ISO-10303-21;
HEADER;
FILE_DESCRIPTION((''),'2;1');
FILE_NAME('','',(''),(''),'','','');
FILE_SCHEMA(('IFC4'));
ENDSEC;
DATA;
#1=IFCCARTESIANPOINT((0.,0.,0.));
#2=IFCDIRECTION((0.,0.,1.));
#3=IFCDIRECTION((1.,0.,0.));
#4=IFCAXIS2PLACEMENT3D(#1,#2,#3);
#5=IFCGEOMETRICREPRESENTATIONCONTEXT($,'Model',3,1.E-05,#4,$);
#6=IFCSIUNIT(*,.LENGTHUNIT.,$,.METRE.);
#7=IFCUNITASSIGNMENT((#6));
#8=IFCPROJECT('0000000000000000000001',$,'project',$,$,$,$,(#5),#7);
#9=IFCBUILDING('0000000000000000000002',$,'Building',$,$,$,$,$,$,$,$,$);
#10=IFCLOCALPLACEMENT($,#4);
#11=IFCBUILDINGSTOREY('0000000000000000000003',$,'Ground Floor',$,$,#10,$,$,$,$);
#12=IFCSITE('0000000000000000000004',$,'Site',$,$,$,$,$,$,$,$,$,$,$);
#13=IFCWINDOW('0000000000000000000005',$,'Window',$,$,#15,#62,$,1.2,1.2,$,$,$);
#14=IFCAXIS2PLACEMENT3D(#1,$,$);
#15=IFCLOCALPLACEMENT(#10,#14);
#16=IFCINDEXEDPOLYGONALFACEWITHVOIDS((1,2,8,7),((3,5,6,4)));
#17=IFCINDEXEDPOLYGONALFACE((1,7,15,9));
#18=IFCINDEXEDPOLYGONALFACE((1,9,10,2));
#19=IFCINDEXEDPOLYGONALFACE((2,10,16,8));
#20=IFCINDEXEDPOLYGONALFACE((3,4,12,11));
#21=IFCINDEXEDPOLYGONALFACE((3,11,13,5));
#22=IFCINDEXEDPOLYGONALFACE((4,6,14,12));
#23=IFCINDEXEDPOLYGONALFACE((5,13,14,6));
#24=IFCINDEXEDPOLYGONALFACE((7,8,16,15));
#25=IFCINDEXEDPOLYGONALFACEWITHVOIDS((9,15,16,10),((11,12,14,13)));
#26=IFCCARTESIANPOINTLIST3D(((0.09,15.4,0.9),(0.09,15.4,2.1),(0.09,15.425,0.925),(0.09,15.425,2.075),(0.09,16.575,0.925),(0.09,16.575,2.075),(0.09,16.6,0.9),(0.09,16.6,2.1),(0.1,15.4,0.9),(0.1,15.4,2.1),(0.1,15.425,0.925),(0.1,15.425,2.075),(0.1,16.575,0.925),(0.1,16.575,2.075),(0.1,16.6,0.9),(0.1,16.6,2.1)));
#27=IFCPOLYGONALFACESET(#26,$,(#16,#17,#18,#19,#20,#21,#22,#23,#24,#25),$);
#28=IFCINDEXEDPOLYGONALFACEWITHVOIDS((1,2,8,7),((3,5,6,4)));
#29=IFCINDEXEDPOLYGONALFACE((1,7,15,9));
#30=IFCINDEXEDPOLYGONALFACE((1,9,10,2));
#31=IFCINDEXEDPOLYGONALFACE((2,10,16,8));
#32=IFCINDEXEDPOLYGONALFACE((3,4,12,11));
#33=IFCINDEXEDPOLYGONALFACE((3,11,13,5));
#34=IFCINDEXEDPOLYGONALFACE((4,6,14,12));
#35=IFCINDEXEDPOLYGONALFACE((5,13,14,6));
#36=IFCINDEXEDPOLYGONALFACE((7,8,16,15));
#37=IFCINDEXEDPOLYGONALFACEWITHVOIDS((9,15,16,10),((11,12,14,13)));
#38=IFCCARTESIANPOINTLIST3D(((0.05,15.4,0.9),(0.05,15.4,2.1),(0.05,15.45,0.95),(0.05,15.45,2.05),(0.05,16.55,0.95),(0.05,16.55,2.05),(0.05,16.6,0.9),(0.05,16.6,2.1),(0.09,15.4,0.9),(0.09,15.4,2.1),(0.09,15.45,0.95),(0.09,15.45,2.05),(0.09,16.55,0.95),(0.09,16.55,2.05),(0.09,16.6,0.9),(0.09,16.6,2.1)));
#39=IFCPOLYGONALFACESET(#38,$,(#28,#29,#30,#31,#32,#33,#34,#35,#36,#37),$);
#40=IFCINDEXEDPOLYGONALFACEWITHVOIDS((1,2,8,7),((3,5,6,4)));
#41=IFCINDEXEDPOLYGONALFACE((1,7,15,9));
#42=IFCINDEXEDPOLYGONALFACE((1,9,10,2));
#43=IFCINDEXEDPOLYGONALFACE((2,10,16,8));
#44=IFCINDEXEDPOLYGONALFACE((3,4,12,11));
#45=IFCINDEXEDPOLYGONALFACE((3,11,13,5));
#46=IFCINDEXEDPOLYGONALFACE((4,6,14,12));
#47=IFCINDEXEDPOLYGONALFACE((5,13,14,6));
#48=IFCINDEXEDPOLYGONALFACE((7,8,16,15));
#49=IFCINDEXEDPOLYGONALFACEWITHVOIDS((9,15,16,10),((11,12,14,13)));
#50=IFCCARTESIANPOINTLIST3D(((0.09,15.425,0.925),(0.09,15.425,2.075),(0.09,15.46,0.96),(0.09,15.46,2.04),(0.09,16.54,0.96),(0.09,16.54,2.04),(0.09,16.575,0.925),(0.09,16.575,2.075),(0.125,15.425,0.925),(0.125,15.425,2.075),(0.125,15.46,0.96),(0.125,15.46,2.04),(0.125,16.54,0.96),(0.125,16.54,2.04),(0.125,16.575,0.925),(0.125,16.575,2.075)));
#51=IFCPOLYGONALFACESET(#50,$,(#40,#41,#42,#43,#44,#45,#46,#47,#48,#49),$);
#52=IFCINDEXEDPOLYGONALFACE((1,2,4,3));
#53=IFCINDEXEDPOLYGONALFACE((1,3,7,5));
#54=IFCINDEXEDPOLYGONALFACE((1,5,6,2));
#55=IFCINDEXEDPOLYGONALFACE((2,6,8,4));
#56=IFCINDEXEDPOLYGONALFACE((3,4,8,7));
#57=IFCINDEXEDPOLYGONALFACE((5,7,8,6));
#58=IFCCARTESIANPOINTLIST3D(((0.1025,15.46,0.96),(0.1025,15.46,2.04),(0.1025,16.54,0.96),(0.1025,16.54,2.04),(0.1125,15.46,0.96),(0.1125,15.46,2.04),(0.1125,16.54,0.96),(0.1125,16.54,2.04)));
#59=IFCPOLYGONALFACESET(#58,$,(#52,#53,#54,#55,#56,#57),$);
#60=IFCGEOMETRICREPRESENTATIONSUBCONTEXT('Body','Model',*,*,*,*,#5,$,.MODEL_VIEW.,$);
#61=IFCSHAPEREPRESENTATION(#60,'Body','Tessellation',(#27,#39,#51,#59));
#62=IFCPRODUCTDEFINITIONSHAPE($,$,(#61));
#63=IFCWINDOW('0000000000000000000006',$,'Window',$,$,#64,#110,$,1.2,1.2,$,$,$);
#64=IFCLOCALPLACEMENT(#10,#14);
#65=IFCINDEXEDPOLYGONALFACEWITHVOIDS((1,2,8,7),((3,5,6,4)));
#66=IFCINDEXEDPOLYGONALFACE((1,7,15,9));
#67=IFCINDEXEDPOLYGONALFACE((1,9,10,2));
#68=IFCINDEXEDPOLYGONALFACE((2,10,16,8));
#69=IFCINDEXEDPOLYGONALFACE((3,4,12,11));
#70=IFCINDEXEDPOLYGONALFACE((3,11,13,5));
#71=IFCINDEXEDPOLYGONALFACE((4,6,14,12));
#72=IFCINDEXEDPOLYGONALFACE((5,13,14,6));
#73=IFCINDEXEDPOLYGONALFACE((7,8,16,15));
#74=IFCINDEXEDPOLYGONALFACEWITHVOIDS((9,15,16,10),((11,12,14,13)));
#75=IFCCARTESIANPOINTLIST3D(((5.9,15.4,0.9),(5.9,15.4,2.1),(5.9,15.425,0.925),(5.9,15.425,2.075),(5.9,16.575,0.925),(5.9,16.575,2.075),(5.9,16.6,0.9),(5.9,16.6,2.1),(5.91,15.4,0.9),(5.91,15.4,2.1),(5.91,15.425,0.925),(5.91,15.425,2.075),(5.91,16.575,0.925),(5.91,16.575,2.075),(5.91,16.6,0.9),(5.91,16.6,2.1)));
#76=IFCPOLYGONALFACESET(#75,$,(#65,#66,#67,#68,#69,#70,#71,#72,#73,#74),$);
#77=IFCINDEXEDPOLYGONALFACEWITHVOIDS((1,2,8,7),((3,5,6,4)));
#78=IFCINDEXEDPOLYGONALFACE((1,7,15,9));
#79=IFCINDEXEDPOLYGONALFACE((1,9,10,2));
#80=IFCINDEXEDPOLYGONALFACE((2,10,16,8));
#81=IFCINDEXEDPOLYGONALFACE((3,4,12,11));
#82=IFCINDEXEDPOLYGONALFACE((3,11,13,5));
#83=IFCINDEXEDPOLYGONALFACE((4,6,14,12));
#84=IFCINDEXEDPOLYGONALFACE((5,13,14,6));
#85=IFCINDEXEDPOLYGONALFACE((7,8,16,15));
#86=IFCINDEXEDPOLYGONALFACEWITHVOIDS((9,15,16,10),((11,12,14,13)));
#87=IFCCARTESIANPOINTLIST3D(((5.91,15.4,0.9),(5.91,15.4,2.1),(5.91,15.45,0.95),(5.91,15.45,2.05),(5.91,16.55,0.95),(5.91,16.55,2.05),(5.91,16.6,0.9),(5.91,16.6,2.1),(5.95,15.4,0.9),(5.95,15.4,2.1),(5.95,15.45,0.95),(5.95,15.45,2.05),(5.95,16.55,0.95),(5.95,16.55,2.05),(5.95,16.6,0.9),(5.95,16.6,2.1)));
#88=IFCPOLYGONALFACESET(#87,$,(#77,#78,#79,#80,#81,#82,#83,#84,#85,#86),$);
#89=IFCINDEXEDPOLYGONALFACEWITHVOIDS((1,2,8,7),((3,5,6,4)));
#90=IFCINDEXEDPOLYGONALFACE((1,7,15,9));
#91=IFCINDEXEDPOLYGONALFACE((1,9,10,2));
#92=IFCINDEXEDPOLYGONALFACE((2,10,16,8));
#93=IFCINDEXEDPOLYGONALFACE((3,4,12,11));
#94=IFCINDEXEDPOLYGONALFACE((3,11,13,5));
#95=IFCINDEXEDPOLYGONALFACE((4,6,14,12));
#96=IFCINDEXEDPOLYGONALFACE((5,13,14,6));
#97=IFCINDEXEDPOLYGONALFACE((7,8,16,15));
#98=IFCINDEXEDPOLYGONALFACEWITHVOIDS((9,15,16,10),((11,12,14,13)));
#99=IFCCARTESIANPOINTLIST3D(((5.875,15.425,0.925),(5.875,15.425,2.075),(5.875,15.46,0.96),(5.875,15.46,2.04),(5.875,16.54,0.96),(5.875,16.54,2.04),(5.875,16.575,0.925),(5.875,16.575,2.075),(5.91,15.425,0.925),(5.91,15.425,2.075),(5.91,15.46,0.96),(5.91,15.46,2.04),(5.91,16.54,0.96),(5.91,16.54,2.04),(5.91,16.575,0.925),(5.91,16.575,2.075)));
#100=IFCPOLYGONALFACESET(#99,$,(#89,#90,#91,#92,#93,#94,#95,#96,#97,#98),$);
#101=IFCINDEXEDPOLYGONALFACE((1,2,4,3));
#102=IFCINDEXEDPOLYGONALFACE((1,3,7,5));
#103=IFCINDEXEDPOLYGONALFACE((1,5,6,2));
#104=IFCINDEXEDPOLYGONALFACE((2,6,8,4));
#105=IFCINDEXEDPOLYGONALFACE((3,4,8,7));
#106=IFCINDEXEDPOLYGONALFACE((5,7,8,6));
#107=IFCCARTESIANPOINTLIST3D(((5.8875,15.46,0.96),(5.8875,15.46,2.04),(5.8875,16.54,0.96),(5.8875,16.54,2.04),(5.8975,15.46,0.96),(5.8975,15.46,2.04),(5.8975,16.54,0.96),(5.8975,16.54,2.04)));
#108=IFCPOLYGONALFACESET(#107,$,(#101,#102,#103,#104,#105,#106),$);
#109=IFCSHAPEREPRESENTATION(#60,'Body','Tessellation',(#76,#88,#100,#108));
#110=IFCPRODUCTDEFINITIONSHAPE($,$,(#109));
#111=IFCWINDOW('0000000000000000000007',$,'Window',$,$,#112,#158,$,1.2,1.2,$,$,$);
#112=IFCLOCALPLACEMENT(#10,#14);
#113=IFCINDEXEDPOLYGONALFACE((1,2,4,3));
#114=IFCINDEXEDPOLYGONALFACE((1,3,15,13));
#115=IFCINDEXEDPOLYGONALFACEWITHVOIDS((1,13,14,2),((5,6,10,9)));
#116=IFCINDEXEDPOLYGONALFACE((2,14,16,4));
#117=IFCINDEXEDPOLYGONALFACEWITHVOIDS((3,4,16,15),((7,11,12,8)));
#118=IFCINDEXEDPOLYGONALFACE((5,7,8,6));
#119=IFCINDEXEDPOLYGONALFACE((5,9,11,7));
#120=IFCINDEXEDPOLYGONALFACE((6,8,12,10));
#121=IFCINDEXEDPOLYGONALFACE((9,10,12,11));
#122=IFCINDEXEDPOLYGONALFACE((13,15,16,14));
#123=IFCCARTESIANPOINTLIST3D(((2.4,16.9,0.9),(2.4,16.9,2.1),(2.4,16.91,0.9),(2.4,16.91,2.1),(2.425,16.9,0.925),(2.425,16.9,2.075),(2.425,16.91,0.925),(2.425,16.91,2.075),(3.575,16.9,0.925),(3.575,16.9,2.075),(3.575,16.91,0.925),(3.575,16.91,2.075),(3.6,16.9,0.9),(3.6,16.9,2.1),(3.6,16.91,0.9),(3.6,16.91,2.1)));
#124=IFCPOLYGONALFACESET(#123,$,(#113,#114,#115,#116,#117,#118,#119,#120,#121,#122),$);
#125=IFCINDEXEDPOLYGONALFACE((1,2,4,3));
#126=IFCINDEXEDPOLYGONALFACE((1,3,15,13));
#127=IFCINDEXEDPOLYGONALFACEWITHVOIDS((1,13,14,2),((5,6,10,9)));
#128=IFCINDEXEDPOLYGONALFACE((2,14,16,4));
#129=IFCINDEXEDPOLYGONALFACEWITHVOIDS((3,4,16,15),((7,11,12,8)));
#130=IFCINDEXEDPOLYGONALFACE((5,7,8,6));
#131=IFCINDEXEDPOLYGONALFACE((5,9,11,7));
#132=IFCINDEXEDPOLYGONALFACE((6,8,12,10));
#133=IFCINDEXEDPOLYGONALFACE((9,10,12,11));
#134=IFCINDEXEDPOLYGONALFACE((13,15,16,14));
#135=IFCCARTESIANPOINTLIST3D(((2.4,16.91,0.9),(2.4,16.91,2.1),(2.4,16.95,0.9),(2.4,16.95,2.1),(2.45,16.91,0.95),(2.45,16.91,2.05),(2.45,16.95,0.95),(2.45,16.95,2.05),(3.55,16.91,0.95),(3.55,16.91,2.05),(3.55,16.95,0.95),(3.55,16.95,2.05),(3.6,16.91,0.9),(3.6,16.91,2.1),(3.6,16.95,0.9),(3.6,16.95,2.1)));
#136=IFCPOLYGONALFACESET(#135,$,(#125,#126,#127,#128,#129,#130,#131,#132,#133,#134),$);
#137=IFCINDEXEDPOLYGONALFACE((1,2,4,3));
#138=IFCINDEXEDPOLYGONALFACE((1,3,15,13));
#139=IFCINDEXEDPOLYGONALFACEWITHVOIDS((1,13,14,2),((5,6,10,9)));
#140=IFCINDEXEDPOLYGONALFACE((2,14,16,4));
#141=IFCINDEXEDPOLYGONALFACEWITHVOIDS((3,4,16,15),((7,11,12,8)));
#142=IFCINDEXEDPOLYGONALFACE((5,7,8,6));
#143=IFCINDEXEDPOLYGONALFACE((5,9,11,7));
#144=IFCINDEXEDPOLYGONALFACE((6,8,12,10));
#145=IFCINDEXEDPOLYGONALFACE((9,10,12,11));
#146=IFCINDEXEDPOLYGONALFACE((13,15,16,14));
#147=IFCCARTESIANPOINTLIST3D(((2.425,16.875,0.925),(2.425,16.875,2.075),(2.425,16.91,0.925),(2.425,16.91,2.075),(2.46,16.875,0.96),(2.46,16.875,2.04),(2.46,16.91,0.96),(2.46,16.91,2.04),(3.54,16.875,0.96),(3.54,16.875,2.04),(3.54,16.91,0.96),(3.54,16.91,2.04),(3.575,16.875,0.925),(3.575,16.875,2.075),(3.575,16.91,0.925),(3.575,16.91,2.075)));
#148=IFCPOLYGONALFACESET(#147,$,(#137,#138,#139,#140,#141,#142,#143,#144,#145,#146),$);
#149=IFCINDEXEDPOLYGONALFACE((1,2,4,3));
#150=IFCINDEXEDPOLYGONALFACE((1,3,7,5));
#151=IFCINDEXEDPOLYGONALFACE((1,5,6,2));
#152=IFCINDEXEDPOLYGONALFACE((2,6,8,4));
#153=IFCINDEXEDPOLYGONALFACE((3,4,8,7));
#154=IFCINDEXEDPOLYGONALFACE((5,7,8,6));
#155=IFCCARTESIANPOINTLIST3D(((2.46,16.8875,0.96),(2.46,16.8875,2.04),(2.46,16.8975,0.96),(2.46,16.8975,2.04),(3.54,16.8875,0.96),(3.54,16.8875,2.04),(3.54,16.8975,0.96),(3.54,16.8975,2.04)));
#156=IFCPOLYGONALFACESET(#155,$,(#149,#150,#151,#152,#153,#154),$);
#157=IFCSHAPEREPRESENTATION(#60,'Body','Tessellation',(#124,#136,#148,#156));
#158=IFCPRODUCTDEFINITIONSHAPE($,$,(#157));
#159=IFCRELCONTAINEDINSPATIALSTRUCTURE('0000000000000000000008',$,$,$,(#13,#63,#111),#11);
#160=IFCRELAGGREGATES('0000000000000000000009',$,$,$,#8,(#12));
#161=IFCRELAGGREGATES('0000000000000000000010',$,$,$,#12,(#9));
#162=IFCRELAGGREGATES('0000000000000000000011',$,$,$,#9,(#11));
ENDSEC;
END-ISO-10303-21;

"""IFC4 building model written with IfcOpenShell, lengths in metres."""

from ifc_helpers import new_model, si_unit, frame, origin_with_axes, place, context, subcontext, project, spatial, line, indexed_curve, outline, extrude, element, save


model = new_model("IFC4")

# Units and contexts
model_context = context("Model", 3, precision=1e-05, world=origin_with_axes())
body_context = subcontext(model_context, "Body", "Model", "MODEL_VIEW")
ifc_project = project(units=[si_unit("LENGTHUNIT", "METRE")], contexts=[model_context])

# Site, building, storey
site = spatial("IfcSite", under=ifc_project, Name="Site")
building = spatial("IfcBuilding", under=site, Name="Building")
storey_placement = place(None, origin_with_axes())
storey = spatial("IfcBuildingStorey", under=building, at=storey_placement, Name="Ground Floor")

# Windows
for number, where, z_axis, x_axis, name in (
    (1, (0.0, 16.6, 0.9), (0.0, 0.0, 1.0), (0.0, -1.0, 0.0), "Window"),
    (2, (6.0, 15.4, 0.9), (0.0, 0.0, 1.0), (0.0, 1.0, 0.0), "Window"),
    (3, (3.6, 17.0, 0.9), (0.0, 0.0, 1.0), (-1.0, 0.0, 0.0), "Window"),
):
    element("IfcWindow", number, at=place(storey_placement, frame(where, z_axis=z_axis, x_axis=x_axis)), inside=storey, Name=name, OverallHeight=1.2, OverallWidth=1.2, context=body_context, shape_type="SweptSolid", body=[
        extrude(outline(indexed_curve([(0.0, 0.0), (1.2, 0.0), (1.2, 1.2), (0.0, 1.2)], segments=[line(1, 2, 3, 4, 1)]), holes=[indexed_curve([(0.025, 0.025), (1.175, 0.025), (1.175, 1.175), (0.025, 1.175)], segments=[line(1, 2, 3, 4, 1)])]), frame((0.0, 0.09, 0.0), z_axis=(0.0, -1.0, 0.0), x_axis=(1.0, 0.0, 0.0)), (0.0, 0.0, -1.0), 0.01),
        extrude(outline(indexed_curve([(0.0, 0.0), (1.2, 0.0), (1.2, 1.2), (0.0, 1.2)], segments=[line(1, 2, 3, 4, 1)]), holes=[indexed_curve([(0.05, 0.05), (1.15, 0.05), (1.15, 1.15), (0.05, 1.15)], segments=[line(1, 2, 3, 4, 1)])]), frame((0.0, 0.05, 0.0), z_axis=(0.0, -1.0, 0.0), x_axis=(1.0, 0.0, 0.0)), (0.0, 0.0, -1.0), 0.04),
        extrude(outline(indexed_curve([(0.0, 0.0), (1.15, 0.0), (1.15, 1.15), (0.0, 1.15)], segments=[line(1, 2, 3, 4, 1)]), holes=[indexed_curve([(0.035, 0.035), (1.115, 0.035), (1.115, 1.115), (0.035, 1.115)], segments=[line(1, 2, 3, 4, 1)])]), frame((0.025, 0.09, 0.025), z_axis=(0.0, -1.0, 0.0), x_axis=(1.0, 0.0, 0.0)), (0.0, 0.0, -1.0), 0.035),
        extrude(outline(indexed_curve([(0.035, 0.035), (1.115, 0.035), (1.115, 1.115), (0.035, 1.115)], segments=[line(1, 2, 3, 4, 1)])), frame((0.025, 0.1025, 0.025), z_axis=(0.0, -1.0, 0.0), x_axis=(1.0, 0.0, 0.0)), (0.0, 0.0, -1.0), 0.01),
    ])

save(model, "model.ifc")
